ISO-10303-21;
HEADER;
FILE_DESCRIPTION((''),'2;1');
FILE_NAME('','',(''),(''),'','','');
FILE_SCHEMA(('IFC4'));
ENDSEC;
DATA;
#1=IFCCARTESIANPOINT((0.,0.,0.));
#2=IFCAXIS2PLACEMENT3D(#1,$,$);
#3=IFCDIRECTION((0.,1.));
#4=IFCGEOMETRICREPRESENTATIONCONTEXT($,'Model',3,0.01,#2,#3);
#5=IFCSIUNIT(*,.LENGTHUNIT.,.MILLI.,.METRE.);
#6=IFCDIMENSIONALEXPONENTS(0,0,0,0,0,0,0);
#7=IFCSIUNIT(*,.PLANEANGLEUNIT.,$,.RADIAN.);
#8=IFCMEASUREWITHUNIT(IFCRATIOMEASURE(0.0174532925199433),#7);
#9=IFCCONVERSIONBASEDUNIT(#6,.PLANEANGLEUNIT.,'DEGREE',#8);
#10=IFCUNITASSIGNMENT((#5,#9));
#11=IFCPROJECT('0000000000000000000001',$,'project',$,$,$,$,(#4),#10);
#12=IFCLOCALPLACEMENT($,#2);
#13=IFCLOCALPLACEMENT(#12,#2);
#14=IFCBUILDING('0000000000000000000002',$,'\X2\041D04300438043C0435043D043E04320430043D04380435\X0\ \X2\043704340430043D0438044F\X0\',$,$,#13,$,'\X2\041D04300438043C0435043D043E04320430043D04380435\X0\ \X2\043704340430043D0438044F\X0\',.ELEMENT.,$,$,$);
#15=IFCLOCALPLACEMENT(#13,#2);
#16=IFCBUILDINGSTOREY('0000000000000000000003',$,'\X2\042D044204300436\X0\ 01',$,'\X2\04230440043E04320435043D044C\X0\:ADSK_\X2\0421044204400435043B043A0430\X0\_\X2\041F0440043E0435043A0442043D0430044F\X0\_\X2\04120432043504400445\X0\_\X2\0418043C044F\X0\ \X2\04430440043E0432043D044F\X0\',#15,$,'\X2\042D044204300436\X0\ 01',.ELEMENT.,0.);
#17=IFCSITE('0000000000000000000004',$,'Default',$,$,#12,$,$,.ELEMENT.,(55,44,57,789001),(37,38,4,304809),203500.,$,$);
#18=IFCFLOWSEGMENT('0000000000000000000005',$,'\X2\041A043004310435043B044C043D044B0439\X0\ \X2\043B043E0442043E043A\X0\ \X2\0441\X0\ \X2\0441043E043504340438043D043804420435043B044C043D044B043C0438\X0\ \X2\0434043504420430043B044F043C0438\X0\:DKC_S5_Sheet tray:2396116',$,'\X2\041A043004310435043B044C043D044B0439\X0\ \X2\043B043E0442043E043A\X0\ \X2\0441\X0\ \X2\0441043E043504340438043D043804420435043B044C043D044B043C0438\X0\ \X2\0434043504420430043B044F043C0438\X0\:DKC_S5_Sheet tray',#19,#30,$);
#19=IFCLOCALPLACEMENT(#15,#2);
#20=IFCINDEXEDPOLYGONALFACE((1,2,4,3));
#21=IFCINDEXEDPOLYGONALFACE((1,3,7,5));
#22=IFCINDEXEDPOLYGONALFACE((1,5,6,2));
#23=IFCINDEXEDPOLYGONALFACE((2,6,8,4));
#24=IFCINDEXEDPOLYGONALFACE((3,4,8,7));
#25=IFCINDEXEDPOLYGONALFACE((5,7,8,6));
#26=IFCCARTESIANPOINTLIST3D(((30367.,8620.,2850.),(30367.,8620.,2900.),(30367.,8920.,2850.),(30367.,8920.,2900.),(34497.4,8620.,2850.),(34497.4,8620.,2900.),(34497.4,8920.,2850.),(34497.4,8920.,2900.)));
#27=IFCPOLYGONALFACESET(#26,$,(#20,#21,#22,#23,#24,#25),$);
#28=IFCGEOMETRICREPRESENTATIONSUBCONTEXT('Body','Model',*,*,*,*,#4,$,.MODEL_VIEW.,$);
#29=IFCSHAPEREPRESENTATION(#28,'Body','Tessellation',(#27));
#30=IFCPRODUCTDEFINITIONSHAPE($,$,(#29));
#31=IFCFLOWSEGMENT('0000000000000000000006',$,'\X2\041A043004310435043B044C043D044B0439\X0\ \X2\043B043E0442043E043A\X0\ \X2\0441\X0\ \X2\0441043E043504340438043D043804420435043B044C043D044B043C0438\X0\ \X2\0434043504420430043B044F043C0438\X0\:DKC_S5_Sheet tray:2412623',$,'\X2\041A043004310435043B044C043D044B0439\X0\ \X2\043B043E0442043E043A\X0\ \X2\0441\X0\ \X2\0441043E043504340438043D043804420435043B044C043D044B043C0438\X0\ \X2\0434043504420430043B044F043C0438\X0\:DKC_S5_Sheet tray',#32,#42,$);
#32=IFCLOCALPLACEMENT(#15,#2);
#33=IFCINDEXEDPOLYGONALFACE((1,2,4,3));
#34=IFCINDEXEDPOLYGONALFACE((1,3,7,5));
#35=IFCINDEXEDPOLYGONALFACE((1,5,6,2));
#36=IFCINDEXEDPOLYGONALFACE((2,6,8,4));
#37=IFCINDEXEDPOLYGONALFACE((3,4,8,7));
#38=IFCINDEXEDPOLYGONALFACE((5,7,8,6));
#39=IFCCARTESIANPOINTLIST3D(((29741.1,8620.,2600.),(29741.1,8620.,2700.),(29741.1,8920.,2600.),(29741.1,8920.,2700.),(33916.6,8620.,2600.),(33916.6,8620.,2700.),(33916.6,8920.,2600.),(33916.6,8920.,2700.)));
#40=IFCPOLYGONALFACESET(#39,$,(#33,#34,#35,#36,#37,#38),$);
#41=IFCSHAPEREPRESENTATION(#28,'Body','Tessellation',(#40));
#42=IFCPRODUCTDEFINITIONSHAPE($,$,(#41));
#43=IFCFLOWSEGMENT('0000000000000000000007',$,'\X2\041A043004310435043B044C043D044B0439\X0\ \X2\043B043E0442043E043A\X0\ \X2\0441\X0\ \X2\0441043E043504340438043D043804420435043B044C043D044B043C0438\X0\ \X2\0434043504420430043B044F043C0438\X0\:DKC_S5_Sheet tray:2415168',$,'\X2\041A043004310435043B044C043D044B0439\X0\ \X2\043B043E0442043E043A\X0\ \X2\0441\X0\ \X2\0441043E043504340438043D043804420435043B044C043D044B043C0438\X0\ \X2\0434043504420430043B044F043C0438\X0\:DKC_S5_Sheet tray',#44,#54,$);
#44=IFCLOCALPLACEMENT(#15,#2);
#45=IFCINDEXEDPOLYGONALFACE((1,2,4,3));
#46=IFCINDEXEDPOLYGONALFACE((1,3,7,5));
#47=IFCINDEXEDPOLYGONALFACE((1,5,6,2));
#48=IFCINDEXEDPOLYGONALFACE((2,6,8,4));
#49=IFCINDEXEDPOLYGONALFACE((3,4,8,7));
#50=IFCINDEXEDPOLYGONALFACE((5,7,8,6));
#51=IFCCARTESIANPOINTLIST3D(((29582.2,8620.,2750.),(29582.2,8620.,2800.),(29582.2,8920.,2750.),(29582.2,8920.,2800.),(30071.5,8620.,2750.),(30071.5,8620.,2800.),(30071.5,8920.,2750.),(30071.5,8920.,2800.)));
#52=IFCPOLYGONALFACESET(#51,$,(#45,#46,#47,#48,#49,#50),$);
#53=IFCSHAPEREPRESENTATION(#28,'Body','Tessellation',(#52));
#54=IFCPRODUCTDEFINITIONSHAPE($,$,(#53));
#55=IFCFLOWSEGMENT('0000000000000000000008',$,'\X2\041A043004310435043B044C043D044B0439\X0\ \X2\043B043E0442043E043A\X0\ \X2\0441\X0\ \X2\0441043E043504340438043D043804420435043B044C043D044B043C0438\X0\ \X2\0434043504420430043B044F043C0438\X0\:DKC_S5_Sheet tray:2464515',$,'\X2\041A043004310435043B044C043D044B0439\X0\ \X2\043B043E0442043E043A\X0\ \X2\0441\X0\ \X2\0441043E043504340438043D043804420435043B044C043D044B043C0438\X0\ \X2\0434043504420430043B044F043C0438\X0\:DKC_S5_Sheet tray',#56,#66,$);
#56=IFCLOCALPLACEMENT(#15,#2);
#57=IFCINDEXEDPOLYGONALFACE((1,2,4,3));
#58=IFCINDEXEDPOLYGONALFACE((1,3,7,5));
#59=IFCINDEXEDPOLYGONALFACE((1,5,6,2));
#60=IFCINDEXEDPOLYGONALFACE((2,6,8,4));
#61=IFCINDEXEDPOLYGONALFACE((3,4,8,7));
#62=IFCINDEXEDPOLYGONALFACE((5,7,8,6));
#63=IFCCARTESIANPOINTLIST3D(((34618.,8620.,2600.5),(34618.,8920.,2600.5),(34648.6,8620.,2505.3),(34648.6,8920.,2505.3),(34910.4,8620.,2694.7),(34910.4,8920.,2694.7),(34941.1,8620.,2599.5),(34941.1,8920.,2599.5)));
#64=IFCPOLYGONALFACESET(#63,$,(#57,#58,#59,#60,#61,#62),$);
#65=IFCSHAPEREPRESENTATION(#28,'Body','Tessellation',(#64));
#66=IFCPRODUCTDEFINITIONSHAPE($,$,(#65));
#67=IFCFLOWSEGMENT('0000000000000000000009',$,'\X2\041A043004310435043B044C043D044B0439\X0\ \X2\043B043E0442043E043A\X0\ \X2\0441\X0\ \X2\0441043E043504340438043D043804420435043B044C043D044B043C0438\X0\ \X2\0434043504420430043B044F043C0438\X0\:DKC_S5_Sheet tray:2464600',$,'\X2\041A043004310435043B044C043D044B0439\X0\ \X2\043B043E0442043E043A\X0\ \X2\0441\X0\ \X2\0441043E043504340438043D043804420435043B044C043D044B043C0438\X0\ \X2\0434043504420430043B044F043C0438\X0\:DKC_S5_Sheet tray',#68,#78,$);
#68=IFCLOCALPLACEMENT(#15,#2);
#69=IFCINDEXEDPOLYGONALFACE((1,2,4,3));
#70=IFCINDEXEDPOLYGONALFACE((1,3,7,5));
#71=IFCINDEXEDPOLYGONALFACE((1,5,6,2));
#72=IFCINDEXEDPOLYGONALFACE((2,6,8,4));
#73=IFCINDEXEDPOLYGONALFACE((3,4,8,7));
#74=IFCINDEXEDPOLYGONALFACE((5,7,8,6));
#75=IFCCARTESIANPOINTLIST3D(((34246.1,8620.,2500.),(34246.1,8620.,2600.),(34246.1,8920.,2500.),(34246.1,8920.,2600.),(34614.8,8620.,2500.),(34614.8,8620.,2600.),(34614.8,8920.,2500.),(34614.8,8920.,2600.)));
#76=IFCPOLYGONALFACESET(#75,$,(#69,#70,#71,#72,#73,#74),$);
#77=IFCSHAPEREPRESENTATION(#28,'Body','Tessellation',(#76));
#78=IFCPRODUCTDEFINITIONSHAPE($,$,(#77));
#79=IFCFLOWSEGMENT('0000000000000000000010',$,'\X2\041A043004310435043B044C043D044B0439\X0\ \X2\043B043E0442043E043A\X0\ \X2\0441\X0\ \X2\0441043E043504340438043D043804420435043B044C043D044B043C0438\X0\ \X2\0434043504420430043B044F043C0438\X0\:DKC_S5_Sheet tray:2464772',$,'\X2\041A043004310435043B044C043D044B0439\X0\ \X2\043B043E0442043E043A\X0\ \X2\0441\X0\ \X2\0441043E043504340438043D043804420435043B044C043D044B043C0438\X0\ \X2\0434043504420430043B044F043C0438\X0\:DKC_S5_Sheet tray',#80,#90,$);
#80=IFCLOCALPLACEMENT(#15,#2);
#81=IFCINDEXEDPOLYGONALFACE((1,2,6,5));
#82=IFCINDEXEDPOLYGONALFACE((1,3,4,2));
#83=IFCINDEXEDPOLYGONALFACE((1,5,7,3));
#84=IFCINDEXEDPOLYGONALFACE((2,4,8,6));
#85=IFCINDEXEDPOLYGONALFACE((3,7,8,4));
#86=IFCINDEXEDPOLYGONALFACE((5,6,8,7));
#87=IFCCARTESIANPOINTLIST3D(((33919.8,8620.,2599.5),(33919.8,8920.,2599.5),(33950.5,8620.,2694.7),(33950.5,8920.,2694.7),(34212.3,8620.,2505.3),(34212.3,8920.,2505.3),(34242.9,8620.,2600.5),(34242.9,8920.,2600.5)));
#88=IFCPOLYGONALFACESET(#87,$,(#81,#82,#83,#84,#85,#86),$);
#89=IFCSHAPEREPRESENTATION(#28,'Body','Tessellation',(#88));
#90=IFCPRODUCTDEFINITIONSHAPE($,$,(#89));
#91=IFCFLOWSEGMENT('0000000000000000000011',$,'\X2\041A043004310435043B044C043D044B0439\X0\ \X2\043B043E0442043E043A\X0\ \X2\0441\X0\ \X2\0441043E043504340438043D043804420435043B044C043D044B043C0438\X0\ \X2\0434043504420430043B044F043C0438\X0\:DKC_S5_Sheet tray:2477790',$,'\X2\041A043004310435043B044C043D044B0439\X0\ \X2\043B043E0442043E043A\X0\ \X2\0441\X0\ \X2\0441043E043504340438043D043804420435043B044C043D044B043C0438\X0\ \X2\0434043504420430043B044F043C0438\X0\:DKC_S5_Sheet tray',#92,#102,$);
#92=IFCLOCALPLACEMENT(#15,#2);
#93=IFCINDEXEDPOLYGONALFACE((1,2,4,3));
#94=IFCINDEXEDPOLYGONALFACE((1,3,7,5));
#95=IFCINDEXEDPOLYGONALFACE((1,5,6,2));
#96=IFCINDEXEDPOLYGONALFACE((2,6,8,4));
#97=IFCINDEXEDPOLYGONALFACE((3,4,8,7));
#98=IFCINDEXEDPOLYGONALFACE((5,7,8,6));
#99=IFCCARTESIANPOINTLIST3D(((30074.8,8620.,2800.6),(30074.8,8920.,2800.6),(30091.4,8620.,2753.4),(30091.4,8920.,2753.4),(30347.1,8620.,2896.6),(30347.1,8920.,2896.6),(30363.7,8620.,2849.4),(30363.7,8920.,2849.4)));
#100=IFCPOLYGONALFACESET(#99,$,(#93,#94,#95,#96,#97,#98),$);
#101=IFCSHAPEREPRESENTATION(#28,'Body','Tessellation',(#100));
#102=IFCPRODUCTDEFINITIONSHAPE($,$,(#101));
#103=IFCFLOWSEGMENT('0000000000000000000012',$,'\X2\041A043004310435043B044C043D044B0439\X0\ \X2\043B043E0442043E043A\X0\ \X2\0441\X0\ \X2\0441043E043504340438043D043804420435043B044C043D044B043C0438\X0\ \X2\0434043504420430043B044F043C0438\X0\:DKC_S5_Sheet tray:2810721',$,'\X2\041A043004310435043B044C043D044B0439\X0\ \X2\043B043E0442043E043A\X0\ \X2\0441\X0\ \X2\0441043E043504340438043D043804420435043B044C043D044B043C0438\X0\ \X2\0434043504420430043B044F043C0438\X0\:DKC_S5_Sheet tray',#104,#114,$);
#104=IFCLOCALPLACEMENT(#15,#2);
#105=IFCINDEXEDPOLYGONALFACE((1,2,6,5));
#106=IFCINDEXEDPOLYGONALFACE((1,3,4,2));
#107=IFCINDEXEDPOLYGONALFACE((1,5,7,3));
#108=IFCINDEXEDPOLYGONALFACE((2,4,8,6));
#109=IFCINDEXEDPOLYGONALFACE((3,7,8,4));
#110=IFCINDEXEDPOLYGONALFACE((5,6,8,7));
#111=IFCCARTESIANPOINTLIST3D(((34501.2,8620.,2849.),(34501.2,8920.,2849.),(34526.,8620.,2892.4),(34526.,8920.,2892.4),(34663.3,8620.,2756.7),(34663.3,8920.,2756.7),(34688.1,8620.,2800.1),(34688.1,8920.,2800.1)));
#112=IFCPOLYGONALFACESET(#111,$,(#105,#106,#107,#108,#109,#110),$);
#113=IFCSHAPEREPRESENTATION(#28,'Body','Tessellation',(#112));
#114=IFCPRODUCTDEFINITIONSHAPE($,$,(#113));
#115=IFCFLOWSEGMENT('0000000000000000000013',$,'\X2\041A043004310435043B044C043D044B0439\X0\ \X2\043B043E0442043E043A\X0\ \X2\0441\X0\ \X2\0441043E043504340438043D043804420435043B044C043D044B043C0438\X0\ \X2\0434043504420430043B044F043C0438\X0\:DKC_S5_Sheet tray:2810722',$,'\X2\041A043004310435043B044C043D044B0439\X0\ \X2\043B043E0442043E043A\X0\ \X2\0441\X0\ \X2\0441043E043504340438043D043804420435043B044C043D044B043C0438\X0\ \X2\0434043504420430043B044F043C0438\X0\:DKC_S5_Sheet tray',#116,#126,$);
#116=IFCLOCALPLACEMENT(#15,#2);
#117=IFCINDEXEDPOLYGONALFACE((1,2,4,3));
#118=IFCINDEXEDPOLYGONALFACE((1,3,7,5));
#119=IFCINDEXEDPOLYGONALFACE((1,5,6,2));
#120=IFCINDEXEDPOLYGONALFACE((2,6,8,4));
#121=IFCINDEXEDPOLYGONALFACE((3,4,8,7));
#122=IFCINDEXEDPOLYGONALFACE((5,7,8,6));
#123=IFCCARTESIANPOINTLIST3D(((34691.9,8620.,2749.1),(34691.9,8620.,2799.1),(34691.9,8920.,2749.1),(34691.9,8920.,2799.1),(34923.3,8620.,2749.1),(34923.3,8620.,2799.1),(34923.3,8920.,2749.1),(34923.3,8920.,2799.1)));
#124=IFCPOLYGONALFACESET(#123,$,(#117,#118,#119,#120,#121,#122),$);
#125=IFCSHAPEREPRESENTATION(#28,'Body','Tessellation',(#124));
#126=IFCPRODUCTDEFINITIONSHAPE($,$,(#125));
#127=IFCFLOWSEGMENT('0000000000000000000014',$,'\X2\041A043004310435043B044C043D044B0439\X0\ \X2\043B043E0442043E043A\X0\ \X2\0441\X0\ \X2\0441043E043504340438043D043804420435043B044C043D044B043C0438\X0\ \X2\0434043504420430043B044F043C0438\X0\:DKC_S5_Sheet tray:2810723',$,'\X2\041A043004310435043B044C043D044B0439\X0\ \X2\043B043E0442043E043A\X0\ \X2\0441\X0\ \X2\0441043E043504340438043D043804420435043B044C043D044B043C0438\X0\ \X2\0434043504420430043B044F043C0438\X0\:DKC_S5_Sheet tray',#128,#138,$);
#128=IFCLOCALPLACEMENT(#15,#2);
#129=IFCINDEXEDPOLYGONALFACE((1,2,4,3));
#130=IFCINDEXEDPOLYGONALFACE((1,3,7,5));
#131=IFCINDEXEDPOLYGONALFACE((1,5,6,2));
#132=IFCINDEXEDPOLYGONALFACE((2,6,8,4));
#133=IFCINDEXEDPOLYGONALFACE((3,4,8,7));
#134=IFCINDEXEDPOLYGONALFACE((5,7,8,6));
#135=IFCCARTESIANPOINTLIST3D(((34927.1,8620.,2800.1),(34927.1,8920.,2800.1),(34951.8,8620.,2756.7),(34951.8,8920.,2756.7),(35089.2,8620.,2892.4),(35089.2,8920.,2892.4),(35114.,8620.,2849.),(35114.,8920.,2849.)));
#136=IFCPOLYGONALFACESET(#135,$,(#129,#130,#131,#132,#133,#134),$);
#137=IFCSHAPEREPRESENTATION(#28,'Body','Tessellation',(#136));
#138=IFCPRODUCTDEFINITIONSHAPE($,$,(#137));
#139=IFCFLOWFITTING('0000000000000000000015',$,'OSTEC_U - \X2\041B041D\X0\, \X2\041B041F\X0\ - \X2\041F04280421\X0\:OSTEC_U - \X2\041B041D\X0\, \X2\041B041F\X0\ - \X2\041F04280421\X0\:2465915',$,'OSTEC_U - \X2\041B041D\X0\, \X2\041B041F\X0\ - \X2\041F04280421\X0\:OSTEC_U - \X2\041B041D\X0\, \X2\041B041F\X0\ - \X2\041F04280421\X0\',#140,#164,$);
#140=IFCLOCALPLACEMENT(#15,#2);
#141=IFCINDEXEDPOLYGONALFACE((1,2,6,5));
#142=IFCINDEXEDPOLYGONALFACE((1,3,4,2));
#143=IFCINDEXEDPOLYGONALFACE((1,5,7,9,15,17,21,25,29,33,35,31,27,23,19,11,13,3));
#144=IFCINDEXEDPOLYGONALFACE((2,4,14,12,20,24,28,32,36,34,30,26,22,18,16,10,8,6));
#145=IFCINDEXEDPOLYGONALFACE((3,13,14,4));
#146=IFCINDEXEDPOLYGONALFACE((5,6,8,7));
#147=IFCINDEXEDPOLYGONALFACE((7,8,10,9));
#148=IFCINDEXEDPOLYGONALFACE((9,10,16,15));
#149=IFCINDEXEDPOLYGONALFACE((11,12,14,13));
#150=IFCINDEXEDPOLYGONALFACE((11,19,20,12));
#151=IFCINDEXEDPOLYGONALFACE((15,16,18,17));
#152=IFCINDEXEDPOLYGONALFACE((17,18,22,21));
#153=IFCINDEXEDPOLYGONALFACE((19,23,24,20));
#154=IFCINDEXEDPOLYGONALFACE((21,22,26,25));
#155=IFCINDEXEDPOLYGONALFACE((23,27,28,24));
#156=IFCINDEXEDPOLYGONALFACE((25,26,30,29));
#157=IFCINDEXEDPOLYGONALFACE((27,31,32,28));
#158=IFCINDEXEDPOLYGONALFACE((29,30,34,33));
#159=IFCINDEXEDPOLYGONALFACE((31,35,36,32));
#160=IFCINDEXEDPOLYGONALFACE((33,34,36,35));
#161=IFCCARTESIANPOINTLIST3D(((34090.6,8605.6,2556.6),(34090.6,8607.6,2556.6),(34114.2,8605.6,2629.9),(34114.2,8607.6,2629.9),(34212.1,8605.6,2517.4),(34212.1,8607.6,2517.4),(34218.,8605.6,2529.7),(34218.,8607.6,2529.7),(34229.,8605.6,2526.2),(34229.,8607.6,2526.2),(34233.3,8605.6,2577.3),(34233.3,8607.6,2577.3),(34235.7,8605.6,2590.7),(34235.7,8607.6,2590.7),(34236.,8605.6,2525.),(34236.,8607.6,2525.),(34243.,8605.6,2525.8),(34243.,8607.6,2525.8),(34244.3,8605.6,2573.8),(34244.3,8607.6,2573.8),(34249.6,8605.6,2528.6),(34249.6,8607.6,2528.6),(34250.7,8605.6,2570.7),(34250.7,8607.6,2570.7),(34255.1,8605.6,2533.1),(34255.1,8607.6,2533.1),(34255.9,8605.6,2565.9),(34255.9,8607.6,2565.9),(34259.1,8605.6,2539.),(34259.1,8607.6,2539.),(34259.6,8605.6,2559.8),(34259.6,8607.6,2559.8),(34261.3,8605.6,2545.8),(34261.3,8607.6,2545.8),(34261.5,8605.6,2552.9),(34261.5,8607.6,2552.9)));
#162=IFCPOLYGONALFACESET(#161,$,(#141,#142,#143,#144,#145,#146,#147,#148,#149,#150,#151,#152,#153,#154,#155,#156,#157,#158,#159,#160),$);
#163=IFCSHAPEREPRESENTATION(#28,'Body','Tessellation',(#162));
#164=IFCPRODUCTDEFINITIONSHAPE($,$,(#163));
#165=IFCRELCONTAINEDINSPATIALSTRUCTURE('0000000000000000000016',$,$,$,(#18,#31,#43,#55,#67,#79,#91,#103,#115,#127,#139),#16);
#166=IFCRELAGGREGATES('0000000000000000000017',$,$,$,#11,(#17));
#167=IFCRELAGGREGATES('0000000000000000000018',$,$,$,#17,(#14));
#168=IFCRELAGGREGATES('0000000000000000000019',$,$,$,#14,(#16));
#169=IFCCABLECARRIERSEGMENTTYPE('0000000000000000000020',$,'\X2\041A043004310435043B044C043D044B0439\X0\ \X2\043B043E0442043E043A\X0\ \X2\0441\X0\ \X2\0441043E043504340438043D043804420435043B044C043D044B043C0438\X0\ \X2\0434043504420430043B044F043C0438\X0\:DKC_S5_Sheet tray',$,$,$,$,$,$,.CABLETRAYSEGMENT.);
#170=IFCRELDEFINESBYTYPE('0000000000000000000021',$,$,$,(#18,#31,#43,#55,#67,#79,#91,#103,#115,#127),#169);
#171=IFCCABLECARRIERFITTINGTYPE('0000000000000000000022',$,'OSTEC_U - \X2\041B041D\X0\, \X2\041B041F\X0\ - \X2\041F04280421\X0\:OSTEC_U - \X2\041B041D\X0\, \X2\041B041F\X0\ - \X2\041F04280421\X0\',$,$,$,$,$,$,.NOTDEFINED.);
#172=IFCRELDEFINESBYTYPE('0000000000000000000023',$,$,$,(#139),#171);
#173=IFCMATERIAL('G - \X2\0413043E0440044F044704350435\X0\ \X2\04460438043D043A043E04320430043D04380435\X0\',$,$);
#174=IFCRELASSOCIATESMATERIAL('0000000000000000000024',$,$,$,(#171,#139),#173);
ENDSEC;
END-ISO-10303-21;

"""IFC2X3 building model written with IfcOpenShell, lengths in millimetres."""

from ifc_helpers import new_model, entity, si_unit, converted_unit, direction, frame, frame_2d, origin, origin_2d_with_axis, place, context, subcontext, project, spatial, polyline, circle_curve, parameter, trimmed, segment, composite_curve, rectangle, outline, extrude, source, transform, mapped, material, type_object, type_shapes, element, save


model = new_model("IFC2X3")

# Units and contexts
model_context = context("Model", 3, precision=0.01, world=origin(), true_north=direction((0.0, 1.0)))
body_context = subcontext(model_context, "Body", "Model", "MODEL_VIEW")
ifc_project = project(units=[si_unit("LENGTHUNIT", "METRE", prefix="MILLI"), converted_unit("PLANEANGLEUNIT", "DEGREE", entity("IfcRatioMeasure", 0.0174532925199433), si_unit("PLANEANGLEUNIT", "RADIAN"), dimensions=[0, 0, 0, 0, 0, 0, 0])], contexts=[model_context])

# Site, building, storey
site_placement = place(None, frame((0.0, 0.0, 0.0)))
site = spatial("IfcSite", under=ifc_project, at=site_placement, Name="Default", CompositionType="ELEMENT", RefLatitude=(55, 44, 57, 789001), RefLongitude=(37, 38, 4, 304809), RefElevation=203500.0)
building_placement = place(site_placement, origin())
building = spatial("IfcBuilding", under=site, at=building_placement, Name="Наименование здания", LongName="Наименование здания", CompositionType="ELEMENT")
storey_placement = place(building_placement, origin())
storey = spatial("IfcBuildingStorey", under=building, at=storey_placement, Name="Этаж 01", ObjectType="Уровень:ADSK_Стрелка_Проектная_Вверх_Имя уровня", LongName="Этаж 01", CompositionType="ELEMENT", Elevation=0.0)

# Flow segments
cable_carrier_segment_type = type_object("IfcCableCarrierSegmentType", Name="Кабельный лоток с соединительными деталями:DKC_S5_Sheet tray", PredefinedType="CABLETRAYSEGMENT")
flow_segment_1_placement = place(storey_placement, frame((30367.0, 8620.0, 2850.0)))
element("IfcFlowSegment", 1, at=flow_segment_1_placement, inside=storey, type_object=cable_carrier_segment_type, Name="Кабельный лоток с соединительными деталями:DKC_S5_Sheet tray:2396116", ObjectType="Кабельный лоток с соединительными деталями:DKC_S5_Sheet tray", context=body_context, shape_type="SweptSolid", body=[
    extrude(rectangle(XDim=4130.4, YDim=300.0, at=frame_2d((0.0, 0.0), x_axis=(1.0, 0.0))), frame((2065.2, 150.0, 0.0)), (0.0, 0.0, 1.0), 50.0),
])
flow_segment_2_placement = place(storey_placement, frame((29741.1, 8620.0, 2600.0)))
element("IfcFlowSegment", 2, at=flow_segment_2_placement, inside=storey, type_object=cable_carrier_segment_type, Name="Кабельный лоток с соединительными деталями:DKC_S5_Sheet tray:2412623", ObjectType="Кабельный лоток с соединительными деталями:DKC_S5_Sheet tray", context=body_context, shape_type="SweptSolid", body=[
    extrude(rectangle(XDim=4175.6, YDim=300.0, at=frame_2d((0.0, 0.0), x_axis=(1.0, 0.0))), frame((2087.8, 150.0, 0.0)), (0.0, 0.0, 1.0), 100.0),
])
flow_segment_3_placement = place(storey_placement, frame((29582.2, 8620.0, 2750.0)))
element("IfcFlowSegment", 3, at=flow_segment_3_placement, inside=storey, type_object=cable_carrier_segment_type, Name="Кабельный лоток с соединительными деталями:DKC_S5_Sheet tray:2415168", ObjectType="Кабельный лоток с соединительными деталями:DKC_S5_Sheet tray", context=body_context, shape_type="SweptSolid", body=[
    extrude(rectangle(XDim=489.4, YDim=300.0, at=origin_2d_with_axis()), frame((244.7, 150.0, 0.0), z_axis=(0.0, 0.0, 1.0), x_axis=(-1.0, 0.0, 0.0)), (0.0, 0.0, 1.0), 50.0),
])
flow_segment_4_placement = place(storey_placement, frame((34618.0, 8620.0, 2505.3)))
element("IfcFlowSegment", 4, at=flow_segment_4_placement, inside=storey, type_object=cable_carrier_segment_type, Name="Кабельный лоток с соединительными деталями:DKC_S5_Sheet tray:2464515", ObjectType="Кабельный лоток с соединительными деталями:DKC_S5_Sheet tray", context=body_context, shape_type="SweptSolid", body=[
    extrude(rectangle(XDim=100.0, YDim=300.0, at=frame_2d((0.0, 0.0), x_axis=(1.0, 0.0))), frame((15.3, 150.0, 47.6), z_axis=(0.951851, 0.0, 0.30656), x_axis=(-0.30656, 0.0, 0.951851)), (0.0, 0.0, 1.0), 307.2),
])
flow_segment_5_placement = place(storey_placement, frame((34246.1, 8620.0, 2500.0)))
element("IfcFlowSegment", 5, at=flow_segment_5_placement, inside=storey, type_object=cable_carrier_segment_type, Name="Кабельный лоток с соединительными деталями:DKC_S5_Sheet tray:2464600", ObjectType="Кабельный лоток с соединительными деталями:DKC_S5_Sheet tray", context=body_context, shape_type="SweptSolid", body=[
    extrude(rectangle(XDim=368.7, YDim=300.0, at=frame_2d((0.0, 0.0), x_axis=(1.0, 0.0))), frame((184.3, 150.0, 0.0), z_axis=(0.0, 0.0, 1.0), x_axis=(-1.0, 0.0, 0.0)), (0.0, 0.0, 1.0), 100.0),
])
flow_segment_6_placement = place(storey_placement, frame((33919.8, 8620.0, 2505.3)))
element("IfcFlowSegment", 6, at=flow_segment_6_placement, inside=storey, type_object=cable_carrier_segment_type, Name="Кабельный лоток с соединительными деталями:DKC_S5_Sheet tray:2464772", ObjectType="Кабельный лоток с соединительными деталями:DKC_S5_Sheet tray", context=body_context, shape_type="SweptSolid", body=[
    extrude(rectangle(XDim=100.0, YDim=300.0, at=frame_2d((0.0, 0.0), x_axis=(0.0, 1.0))), frame((15.3, 150.0, 141.8), z_axis=(0.951851, 0.0, -0.30656), x_axis=(0.0, 1.0, 0.0)), (0.0, 0.0, 1.0), 307.2),
])
flow_segment_7_placement = place(storey_placement, frame((30074.8, 8620.0, 2753.4)))
element("IfcFlowSegment", 7, at=flow_segment_7_placement, inside=storey, type_object=cable_carrier_segment_type, Name="Кабельный лоток с соединительными деталями:DKC_S5_Sheet tray:2477790", ObjectType="Кабельный лоток с соединительными деталями:DKC_S5_Sheet tray", context=body_context, shape_type="SweptSolid", body=[
    extrude(rectangle(XDim=50.0, YDim=288.8, at=frame_2d((0.0, 0.0), x_axis=(0.0, 1.0))), frame((144.5, 0.0, 71.6), z_axis=(0.0, 1.0, 0.0), x_axis=(0.943075, 0.0, 0.332579)), (0.0, 0.0, 1.0), 300.0),
])
flow_segment_8_placement = place(storey_placement, frame((34501.2, 8620.0, 2756.7)))
element("IfcFlowSegment", 8, at=flow_segment_8_placement, inside=storey, type_object=cable_carrier_segment_type, Name="Кабельный лоток с соединительными деталями:DKC_S5_Sheet tray:2810721", ObjectType="Кабельный лоток с соединительными деталями:DKC_S5_Sheet tray", context=body_context, shape_type="SweptSolid", body=[
    extrude(rectangle(XDim=50.0, YDim=186.6, at=frame_2d((0.0, 0.0), x_axis=(0.0, 1.0))), frame((93.4, 0.0, 67.9), z_axis=(0.0, 1.0, 0.0), x_axis=(0.869016, 0.0, -0.494783)), (0.0, 0.0, 1.0), 300.0),
])
flow_segment_9_placement = place(storey_placement, frame((34691.9, 8620.0, 2749.1)))
element("IfcFlowSegment", 9, at=flow_segment_9_placement, inside=storey, type_object=cable_carrier_segment_type, Name="Кабельный лоток с соединительными деталями:DKC_S5_Sheet tray:2810722", ObjectType="Кабельный лоток с соединительными деталями:DKC_S5_Sheet tray", context=body_context, shape_type="SweptSolid", body=[
    extrude(rectangle(XDim=231.3, YDim=300.0, at=frame_2d((0.0, 0.0), x_axis=(1.0, 0.0))), frame((115.7, 150.0, 0.0)), (0.0, 0.0, 1.0), 50.0),
])
flow_segment_10_placement = place(storey_placement, frame((34927.1, 8620.0, 2756.7)))
element("IfcFlowSegment", 10, at=flow_segment_10_placement, inside=storey, type_object=cable_carrier_segment_type, Name="Кабельный лоток с соединительными деталями:DKC_S5_Sheet tray:2810723", ObjectType="Кабельный лоток с соединительными деталями:DKC_S5_Sheet tray", context=body_context, shape_type="SweptSolid", body=[
    extrude(rectangle(XDim=50.0, YDim=186.6, at=frame_2d((0.0, 0.0), x_axis=(0.0, 1.0))), frame((93.4, 0.0, 67.9), z_axis=(0.0, 1.0, 0.0), x_axis=(-0.869016, 0.0, -0.494783)), (0.0, 0.0, 1.0), 300.0),
])

# Flow fitting
ifc_material = material(Name="G - Горячее цинкование")
cable_carrier_fitting_type_1 = type_object("IfcCableCarrierFittingType", Name="OSTEC_U - ЛН, ЛП - ПШС:OSTEC_U - ЛН, ЛП - ПШС", PredefinedType="NOTDEFINED", material=ifc_material)
shared_shape_1 = source(origin(), body_context, "Body", "SweptSolid", [
    extrude(outline(composite_curve([segment(trimmed(circle_curve(frame_2d((-41.5, 0.0), x_axis=(1.0, 0.0)), 25.0), [parameter(90.0)], [parameter(270.0)], True, "PARAMETER"), True, "CONTINUOUS"), segment(polyline([(-41.5, -25.0), (-30.0, -25.0)]), True, "CONTINUOUS"), segment(polyline([(-30.0, -25.0), (-28.1, -38.5)]), True, "CONTINUOUS"), segment(polyline([(-28.1, -38.5), (99.5, -38.5)]), True, "CONTINUOUS"), segment(polyline([(99.5, -38.5), (99.5, 38.5)]), True, "CONTINUOUS"), segment(polyline([(99.5, 38.5), (-28.1, 38.5)]), True, "CONTINUOUS"), segment(polyline([(-28.1, 38.5), (-30.0, 25.0)]), True, "CONTINUOUS"), segment(polyline([(-30.0, 25.0), (-41.5, 25.0)]), True, "CONTINUOUS")], self_intersect=False)), frame((41.5, 0.0, 0.0), z_axis=(0.0, 0.0, -1.0), x_axis=(1.0, 0.0, 0.0)), (0.0, 0.0, -1.0), 2.0),
])
type_shapes(cable_carrier_fitting_type_1, [shared_shape_1])
flow_fitting_1_placement = place(storey_placement, frame((34236.6, 8605.6, 2550.0), z_axis=(0.0, 1.0, 0.0), x_axis=(-0.951851, 0.0, 0.30656)))
element("IfcFlowFitting", 11, at=flow_fitting_1_placement, inside=storey, type_object=cable_carrier_fitting_type_1, material=ifc_material, Name="OSTEC_U - ЛН, ЛП - ПШС:OSTEC_U - ЛН, ЛП - ПШС:2465915", ObjectType="OSTEC_U - ЛН, ЛП - ПШС:OSTEC_U - ЛН, ЛП - ПШС", context=body_context, shape_type="MappedRepresentation", body=[
    mapped(shared_shape_1, transform((0.0, 0.0, 0.0), scale=1.0)),
])

save(model, "model.ifc")
